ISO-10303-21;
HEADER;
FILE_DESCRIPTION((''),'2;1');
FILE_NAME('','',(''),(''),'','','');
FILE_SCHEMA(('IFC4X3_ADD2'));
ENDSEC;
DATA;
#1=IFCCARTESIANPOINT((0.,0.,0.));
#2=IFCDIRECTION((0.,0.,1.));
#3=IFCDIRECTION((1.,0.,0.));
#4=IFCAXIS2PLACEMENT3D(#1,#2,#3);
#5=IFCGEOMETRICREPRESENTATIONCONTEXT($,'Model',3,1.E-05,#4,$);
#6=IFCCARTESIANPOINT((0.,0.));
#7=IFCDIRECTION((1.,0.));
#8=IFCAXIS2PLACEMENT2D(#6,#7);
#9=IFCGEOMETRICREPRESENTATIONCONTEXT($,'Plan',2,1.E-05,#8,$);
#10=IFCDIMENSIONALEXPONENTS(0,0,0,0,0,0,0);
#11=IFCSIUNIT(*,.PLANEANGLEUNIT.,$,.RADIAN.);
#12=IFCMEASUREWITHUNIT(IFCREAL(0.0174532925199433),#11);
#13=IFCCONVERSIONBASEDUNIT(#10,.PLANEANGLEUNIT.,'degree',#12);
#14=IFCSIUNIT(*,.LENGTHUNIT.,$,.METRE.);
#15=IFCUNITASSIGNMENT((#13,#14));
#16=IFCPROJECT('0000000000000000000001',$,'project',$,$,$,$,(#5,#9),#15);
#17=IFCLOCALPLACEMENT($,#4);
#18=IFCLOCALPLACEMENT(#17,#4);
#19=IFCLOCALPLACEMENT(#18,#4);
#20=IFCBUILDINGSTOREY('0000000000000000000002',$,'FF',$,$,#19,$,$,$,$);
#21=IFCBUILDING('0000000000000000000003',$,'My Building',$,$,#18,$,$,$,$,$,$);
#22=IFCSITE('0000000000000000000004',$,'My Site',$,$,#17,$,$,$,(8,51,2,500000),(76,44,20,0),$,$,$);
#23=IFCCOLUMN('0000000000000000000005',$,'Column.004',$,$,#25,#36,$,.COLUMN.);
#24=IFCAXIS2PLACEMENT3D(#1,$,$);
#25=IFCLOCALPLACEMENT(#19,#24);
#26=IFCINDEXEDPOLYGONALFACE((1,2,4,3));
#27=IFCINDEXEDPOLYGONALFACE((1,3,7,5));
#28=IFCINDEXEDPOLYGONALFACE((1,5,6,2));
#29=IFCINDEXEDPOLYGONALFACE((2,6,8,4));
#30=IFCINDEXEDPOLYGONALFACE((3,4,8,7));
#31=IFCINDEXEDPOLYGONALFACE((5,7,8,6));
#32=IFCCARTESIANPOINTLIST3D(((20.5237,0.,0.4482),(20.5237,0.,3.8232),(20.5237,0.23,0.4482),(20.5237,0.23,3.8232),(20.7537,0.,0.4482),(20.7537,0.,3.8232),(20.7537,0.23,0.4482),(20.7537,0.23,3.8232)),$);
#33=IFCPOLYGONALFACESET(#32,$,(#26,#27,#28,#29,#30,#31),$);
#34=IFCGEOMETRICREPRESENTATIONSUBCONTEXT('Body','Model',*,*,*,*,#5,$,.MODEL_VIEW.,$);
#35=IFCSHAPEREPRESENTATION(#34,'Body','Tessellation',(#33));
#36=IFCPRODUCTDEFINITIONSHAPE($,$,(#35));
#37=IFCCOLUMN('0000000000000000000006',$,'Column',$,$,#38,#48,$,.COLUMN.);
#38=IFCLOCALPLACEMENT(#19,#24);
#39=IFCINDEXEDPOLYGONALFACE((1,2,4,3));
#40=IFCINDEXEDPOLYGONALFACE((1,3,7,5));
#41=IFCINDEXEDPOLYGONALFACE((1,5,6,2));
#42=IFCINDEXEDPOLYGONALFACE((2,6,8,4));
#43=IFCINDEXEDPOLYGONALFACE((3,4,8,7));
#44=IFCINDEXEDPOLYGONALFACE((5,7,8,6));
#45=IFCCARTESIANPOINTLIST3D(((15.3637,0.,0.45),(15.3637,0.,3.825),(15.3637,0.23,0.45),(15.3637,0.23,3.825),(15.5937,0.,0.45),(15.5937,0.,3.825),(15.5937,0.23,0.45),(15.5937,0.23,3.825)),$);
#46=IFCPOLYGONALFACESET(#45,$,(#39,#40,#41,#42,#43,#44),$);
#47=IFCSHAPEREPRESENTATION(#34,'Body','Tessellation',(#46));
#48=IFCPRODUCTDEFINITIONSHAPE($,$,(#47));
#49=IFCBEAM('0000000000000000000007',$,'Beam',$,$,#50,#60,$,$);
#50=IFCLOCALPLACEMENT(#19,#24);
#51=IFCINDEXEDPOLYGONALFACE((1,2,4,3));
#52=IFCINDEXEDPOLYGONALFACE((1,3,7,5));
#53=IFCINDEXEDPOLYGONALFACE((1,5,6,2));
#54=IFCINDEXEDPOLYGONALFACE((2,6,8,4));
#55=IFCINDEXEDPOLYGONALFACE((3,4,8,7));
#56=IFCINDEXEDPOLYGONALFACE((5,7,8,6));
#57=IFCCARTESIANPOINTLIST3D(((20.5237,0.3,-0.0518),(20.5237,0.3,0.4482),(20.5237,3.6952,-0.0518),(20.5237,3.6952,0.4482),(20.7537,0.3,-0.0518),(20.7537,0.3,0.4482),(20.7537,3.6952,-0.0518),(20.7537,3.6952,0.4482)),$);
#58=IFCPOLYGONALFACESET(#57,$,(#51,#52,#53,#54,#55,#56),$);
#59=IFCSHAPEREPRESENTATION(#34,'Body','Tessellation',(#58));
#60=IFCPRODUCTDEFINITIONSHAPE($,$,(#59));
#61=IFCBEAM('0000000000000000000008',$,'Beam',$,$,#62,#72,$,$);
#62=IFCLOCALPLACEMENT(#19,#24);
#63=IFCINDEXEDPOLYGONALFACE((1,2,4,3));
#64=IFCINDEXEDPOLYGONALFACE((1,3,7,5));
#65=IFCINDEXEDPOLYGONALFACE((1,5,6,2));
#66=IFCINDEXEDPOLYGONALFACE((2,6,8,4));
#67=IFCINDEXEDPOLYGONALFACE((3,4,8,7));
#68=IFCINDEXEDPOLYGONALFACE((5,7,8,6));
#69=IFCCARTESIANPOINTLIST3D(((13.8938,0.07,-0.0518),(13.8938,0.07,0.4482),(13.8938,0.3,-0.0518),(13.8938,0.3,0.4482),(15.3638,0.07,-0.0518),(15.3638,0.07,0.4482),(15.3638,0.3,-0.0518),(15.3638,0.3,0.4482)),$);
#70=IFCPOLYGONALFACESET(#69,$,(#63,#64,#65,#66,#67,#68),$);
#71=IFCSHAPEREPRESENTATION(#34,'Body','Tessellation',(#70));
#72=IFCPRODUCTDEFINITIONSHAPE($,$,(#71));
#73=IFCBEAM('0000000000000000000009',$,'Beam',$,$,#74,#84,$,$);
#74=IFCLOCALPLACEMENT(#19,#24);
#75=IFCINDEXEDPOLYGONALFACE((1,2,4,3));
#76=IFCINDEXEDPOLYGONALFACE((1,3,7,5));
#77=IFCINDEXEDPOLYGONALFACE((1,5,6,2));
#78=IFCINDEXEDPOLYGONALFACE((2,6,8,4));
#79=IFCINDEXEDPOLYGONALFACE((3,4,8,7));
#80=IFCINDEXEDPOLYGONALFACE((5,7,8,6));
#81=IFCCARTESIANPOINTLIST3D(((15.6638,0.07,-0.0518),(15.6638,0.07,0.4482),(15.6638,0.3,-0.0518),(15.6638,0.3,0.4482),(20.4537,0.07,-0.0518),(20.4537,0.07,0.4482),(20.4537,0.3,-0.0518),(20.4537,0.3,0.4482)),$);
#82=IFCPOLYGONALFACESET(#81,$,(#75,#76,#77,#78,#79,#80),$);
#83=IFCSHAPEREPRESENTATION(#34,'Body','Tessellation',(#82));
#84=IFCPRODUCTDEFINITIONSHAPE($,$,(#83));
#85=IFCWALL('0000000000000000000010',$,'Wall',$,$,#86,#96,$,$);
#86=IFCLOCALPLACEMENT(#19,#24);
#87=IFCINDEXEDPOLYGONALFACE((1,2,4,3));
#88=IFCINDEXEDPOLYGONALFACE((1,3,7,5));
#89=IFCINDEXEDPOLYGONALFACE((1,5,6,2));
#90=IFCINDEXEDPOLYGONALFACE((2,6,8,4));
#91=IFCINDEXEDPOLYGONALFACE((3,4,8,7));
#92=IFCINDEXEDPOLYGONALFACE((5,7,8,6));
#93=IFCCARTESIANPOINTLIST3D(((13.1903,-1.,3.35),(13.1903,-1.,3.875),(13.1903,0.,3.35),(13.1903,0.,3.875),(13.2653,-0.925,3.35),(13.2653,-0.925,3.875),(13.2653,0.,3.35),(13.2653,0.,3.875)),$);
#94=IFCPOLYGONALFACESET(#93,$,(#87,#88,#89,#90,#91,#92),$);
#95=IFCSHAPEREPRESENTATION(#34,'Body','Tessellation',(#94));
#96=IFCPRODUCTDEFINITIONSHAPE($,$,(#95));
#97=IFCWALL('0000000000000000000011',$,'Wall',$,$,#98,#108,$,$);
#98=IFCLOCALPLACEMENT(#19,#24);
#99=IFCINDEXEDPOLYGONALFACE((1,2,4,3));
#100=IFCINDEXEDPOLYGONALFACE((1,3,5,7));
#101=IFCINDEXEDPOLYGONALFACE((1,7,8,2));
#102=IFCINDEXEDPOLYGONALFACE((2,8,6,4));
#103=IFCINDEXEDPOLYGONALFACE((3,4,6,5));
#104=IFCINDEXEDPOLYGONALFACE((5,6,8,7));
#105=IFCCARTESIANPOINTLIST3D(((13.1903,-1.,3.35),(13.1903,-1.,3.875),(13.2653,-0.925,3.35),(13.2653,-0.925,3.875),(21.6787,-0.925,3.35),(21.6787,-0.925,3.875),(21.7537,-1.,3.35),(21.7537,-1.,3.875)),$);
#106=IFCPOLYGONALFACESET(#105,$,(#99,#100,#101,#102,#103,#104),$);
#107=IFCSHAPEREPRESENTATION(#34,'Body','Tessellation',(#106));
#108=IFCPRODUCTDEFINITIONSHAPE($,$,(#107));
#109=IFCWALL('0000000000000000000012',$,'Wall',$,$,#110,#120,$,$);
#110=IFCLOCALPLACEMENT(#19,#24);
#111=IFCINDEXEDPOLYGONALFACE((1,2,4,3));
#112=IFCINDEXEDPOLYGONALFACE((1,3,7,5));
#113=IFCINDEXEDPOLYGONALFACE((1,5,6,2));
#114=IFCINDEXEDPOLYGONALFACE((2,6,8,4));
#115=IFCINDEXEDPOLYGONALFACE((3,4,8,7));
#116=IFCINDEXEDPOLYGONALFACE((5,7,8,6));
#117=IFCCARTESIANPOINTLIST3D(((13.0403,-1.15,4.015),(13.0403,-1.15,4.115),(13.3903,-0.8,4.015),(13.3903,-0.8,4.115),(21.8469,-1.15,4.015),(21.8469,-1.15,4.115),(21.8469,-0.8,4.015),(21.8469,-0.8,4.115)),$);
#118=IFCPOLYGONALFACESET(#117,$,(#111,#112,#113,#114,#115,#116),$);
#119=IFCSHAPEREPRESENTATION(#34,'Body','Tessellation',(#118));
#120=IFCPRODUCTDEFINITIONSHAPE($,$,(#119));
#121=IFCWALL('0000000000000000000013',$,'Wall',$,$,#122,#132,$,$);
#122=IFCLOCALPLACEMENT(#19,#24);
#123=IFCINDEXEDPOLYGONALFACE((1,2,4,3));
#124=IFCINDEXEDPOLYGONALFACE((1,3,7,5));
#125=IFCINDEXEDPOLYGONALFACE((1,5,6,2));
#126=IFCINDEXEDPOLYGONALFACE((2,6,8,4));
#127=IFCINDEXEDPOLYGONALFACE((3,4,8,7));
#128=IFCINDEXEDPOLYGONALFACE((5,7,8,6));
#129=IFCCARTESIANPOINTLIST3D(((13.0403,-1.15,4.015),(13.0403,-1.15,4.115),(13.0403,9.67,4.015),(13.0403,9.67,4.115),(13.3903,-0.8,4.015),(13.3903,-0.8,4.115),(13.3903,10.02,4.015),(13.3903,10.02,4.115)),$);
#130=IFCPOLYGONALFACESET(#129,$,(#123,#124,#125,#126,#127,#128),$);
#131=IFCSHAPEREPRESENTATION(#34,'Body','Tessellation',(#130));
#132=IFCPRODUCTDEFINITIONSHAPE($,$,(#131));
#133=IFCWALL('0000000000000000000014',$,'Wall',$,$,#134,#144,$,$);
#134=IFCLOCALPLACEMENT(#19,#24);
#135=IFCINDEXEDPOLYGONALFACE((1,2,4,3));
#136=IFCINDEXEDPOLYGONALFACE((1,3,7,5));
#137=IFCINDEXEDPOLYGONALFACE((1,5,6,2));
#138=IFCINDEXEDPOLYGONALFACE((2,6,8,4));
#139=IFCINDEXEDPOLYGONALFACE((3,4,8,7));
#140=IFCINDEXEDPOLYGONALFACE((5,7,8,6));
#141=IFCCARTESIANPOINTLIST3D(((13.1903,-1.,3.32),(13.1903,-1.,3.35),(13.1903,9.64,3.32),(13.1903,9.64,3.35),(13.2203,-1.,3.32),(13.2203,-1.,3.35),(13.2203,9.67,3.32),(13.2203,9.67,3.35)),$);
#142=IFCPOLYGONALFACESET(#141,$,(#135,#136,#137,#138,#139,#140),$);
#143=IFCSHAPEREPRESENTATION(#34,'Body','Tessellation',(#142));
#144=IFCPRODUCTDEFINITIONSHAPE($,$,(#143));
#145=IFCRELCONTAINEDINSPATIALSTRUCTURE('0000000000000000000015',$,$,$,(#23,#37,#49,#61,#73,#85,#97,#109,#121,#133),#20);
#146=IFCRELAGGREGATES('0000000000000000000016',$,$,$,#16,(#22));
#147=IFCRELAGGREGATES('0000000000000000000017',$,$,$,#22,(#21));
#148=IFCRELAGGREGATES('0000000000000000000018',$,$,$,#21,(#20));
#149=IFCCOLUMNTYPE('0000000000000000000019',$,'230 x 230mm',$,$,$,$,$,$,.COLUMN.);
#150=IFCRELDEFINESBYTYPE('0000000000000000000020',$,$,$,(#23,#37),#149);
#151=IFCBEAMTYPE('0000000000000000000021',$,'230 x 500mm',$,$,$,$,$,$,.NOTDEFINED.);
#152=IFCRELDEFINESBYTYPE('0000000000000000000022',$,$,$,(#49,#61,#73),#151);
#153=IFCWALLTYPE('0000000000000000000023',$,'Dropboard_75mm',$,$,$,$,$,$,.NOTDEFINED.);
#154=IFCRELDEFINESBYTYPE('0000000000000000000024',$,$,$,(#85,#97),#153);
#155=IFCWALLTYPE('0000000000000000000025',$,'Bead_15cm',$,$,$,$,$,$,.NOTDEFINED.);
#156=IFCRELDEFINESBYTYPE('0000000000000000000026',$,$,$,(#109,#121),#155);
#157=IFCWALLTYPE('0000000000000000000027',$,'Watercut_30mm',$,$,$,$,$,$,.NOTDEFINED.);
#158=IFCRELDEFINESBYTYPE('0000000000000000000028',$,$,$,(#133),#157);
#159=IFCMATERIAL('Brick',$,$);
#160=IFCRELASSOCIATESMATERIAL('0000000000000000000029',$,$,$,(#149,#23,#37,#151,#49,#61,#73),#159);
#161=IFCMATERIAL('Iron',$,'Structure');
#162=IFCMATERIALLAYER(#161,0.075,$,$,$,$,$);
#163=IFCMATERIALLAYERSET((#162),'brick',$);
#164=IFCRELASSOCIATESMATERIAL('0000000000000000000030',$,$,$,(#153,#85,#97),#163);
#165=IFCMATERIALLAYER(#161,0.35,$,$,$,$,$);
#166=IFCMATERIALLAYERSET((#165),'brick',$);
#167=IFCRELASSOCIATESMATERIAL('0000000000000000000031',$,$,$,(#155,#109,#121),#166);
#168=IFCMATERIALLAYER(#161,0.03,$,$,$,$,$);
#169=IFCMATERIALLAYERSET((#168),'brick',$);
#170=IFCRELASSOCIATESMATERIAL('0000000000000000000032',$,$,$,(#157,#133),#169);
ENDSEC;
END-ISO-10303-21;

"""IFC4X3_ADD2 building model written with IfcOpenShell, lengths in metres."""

from ifc_helpers import new_model, entity, si_unit, converted_unit, frame, origin_with_axes, origin_2d_with_axis, place, context, subcontext, project, spatial, line, indexed_curve, rectangle, outline, extrude, material, layer, layer_set, layer_usage, material_profile, profile_set, profile_usage, type_object, element, save


model = new_model("IFC4X3_ADD2")

# Units and contexts
model_context = context("Model", 3, precision=1e-05, world=origin_with_axes())
plan_context = context("Plan", 2, precision=1e-05, world=origin_2d_with_axis())
body_context = subcontext(model_context, "Body", "Model", "MODEL_VIEW")
ifc_project = project(units=[converted_unit("PLANEANGLEUNIT", "degree", entity("IfcReal", 0.0174532925199433), si_unit("PLANEANGLEUNIT", "RADIAN"), dimensions=[0, 0, 0, 0, 0, 0, 0]), si_unit("LENGTHUNIT", "METRE")], contexts=[model_context, plan_context])

# Site, building, storey
site_placement = place(None, origin_with_axes())
site = spatial("IfcSite", under=ifc_project, at=site_placement, Name="My Site", RefLatitude=(8, 51, 2, 500000), RefLongitude=(76, 44, 20, 0))
building_placement = place(site_placement, origin_with_axes())
building = spatial("IfcBuilding", under=site, at=building_placement, Name="My Building")
storey_placement = place(building_placement, origin_with_axes())
storey = spatial("IfcBuildingStorey", under=building, at=storey_placement, Name="FF")

# Columns
ifc_material_1 = material(Name="Brick")
ifc_material_profile_1 = material_profile(ifc_material_1, outline(indexed_curve([(-0.115, 0.115), (0.115, 0.115), (0.115, -0.115), (-0.115, -0.115), (-0.115, 0.115)])))
ifc_profile_set_1 = profile_set([ifc_material_profile_1])
ifc_profile_usage_1 = profile_usage(ifc_profile_set_1)
column_type = type_object("IfcColumnType", Name="230 x 230mm", PredefinedType="COLUMN", material=ifc_profile_set_1)
column_1_placement = place(storey_placement, frame((20.6387, 0.115, 0.4482), z_axis=(0.0, 0.0, 1.0), x_axis=(1.0, 0.0, 0.0)))
element("IfcColumn", 1, at=column_1_placement, inside=storey, type_object=column_type, material=ifc_profile_usage_1, Name="Column.004", PredefinedType="COLUMN", context=body_context, shape_type="SweptSolid", body=[
    extrude(outline(indexed_curve([(-0.115, 0.115), (0.115, 0.115), (0.115, -0.115), (-0.115, -0.115), (-0.115, 0.115)])), origin_with_axes(), (0.0, 0.0, 1.0), 3.375),
])
ifc_profile_usage_2 = profile_usage(ifc_profile_set_1)
column_2_placement = place(storey_placement, frame((15.4787, 0.115, 0.45), z_axis=(0.0, 0.0, 1.0), x_axis=(1.0, 0.0, 0.0)))
element("IfcColumn", 2, at=column_2_placement, inside=storey, type_object=column_type, material=ifc_profile_usage_2, Name="Column", PredefinedType="COLUMN", context=body_context, shape_type="SweptSolid", body=[
    extrude(outline(indexed_curve([(-0.115, 0.115), (0.115, 0.115), (0.115, -0.115), (-0.115, -0.115), (-0.115, 0.115)])), origin_with_axes(), (0.0, 0.0, 1.0), 3.375),
])

# Beams
ifc_material_profile_2 = material_profile(ifc_material_1, rectangle(XDim=0.23, YDim=0.5))
ifc_profile_set_2 = profile_set([ifc_material_profile_2], Name="rcc")
ifc_profile_usage_3 = profile_usage(ifc_profile_set_2)
beam_type = type_object("IfcBeamType", Name="230 x 500mm", PredefinedType="NOTDEFINED", material=ifc_profile_set_2)
beam_1_placement = place(storey_placement, frame((20.6387, 0.3, 0.1982), z_axis=(0.0, 1.0, 0.0), x_axis=(-1.0, 0.0, 0.0)))
element("IfcBeam", 3, at=beam_1_placement, inside=storey, type_object=beam_type, material=ifc_profile_usage_3, Name="Beam", context=body_context, shape_type="SweptSolid", body=[
    extrude(rectangle(XDim=0.23, YDim=0.5), origin_with_axes(), (0.0, 0.0, 1.0), 3.3952),
])
ifc_profile_usage_4 = profile_usage(ifc_profile_set_2)
beam_2_placement = place(storey_placement, frame((15.3638, 0.185, 0.1982), z_axis=(-1.0, 0.0, 0.0), x_axis=(0.0, -1.0, 0.0)))
element("IfcBeam", 4, at=beam_2_placement, inside=storey, type_object=beam_type, material=ifc_profile_usage_4, Name="Beam", context=body_context, shape_type="SweptSolid", body=[
    extrude(rectangle(XDim=0.23, YDim=0.5), origin_with_axes(), (0.0, 0.0, 1.0), 1.47),
])
ifc_profile_usage_5 = profile_usage(ifc_profile_set_2)
beam_3_placement = place(storey_placement, frame((20.4537, 0.185, 0.1982), z_axis=(-1.0, 0.0, 0.0), x_axis=(0.0, -1.0, 0.0)))
element("IfcBeam", 5, at=beam_3_placement, inside=storey, type_object=beam_type, material=ifc_profile_usage_5, Name="Beam", context=body_context, shape_type="SweptSolid", body=[
    extrude(rectangle(XDim=0.23, YDim=0.5), origin_with_axes(), (0.0, 0.0, 1.0), 4.7899),
])

# Walls
ifc_material_2 = material(Name="Iron", Category="Structure")
ifc_layer_1 = layer(ifc_material_2, 0.075)
ifc_layer_set_1 = layer_set([ifc_layer_1], Name="brick")
ifc_layer_usage_1 = layer_usage(ifc_layer_set_1, "AXIS2", "POSITIVE", 0.0)
wall_type_1 = type_object("IfcWallType", Name="Dropboard_75mm", PredefinedType="NOTDEFINED", material=ifc_layer_set_1)
wall_1_placement = place(storey_placement, frame((13.2653, -1.0, 3.35), z_axis=(0.0, 0.0, 1.0), x_axis=(0.0, 1.0, 0.0)))
element("IfcWall", 6, at=wall_1_placement, inside=storey, type_object=wall_type_1, material=ifc_layer_usage_1, Name="Wall", context=body_context, shape_type="SweptSolid", body=[
    extrude(outline(indexed_curve([(0.075, 0.0), (0.0, 0.075), (1.0, 0.075), (1.0, 0.0)], segments=[line(1, 2, 3, 4, 1)])), origin_with_axes(), (0.0, 0.0, 1.0), 0.525),
])
ifc_layer_usage_2 = layer_usage(ifc_layer_set_1, "AXIS2", "POSITIVE", 0.0)
wall_2_placement = place(storey_placement, frame((13.2653, -1.0, 3.35), z_axis=(0.0, 0.0, 1.0), x_axis=(1.0, -0.000001, 0.0)))
element("IfcWall", 7, at=wall_2_placement, inside=storey, type_object=wall_type_1, material=ifc_layer_usage_2, Name="Wall", context=body_context, shape_type="SweptSolid", body=[
    extrude(outline(indexed_curve([(-0.075, 0.0), (0.0, 0.075), (8.4134, 0.075), (8.4884, 0.0)], segments=[line(1, 2, 3, 4, 1)])), origin_with_axes(), (0.0, 0.0, 1.0), 0.525),
])
ifc_layer_2 = layer(ifc_material_2, 0.35)
ifc_layer_set_2 = layer_set([ifc_layer_2], Name="brick")
ifc_layer_usage_3 = layer_usage(ifc_layer_set_2, "AXIS2", "POSITIVE", 0.0)
wall_type_2 = type_object("IfcWallType", Name="Bead_15cm", PredefinedType="NOTDEFINED", material=ifc_layer_set_2)
wall_3_placement = place(storey_placement, frame((13.3903, -1.15, 4.015), z_axis=(0.0, 0.0, 1.0), x_axis=(1.0, -0.000001, 0.0)))
element("IfcWall", 8, at=wall_3_placement, inside=storey, type_object=wall_type_2, material=ifc_layer_usage_3, Name="Wall", context=body_context, shape_type="SweptSolid", body=[
    extrude(outline(indexed_curve([(-0.35, 0.0), (0.0, 0.35), (8.4566, 0.35), (8.4566, 0.0)], segments=[line(1, 2, 3, 4, 1)])), origin_with_axes(), (0.0, 0.0, 1.0), 0.1),
])
ifc_layer_usage_4 = layer_usage(ifc_layer_set_2, "AXIS2", "POSITIVE", 0.0)
wall_4_placement = place(storey_placement, frame((13.3903, -1.15, 4.015), z_axis=(0.0, 0.0, 1.0), x_axis=(0.000001, 1.0, 0.0)))
element("IfcWall", 9, at=wall_4_placement, inside=storey, type_object=wall_type_2, material=ifc_layer_usage_4, Name="Wall", context=body_context, shape_type="SweptSolid", body=[
    extrude(outline(indexed_curve([(0.35, 0.0), (0.0, 0.35), (10.82, 0.35), (11.17, 0.0)], segments=[line(1, 2, 3, 4, 1)])), origin_with_axes(), (0.0, 0.0, 1.0), 0.1),
])
ifc_layer_3 = layer(ifc_material_2, 0.03)
ifc_layer_set_3 = layer_set([ifc_layer_3], Name="brick")
ifc_layer_usage_5 = layer_usage(ifc_layer_set_3, "AXIS2", "POSITIVE", 0.0)
wall_type_3 = type_object("IfcWallType", Name="Watercut_30mm", PredefinedType="NOTDEFINED", material=ifc_layer_set_3)
wall_5_placement = place(storey_placement, frame((13.2203, -1.0, 3.32), z_axis=(0.0, 0.0, 1.0), x_axis=(0.000001, 1.0, 0.0)))
element("IfcWall", 10, at=wall_5_placement, inside=storey, type_object=wall_type_3, material=ifc_layer_usage_5, Name="Wall", context=body_context, shape_type="SweptSolid", body=[
    extrude(outline(indexed_curve([(0.0, 0.0), (0.0, 0.03), (10.64, 0.03), (10.67, 0.0)], segments=[line(1, 2, 3, 4, 1)])), origin_with_axes(), (0.0, 0.0, 1.0), 0.03),
])

save(model, "model.ifc")
